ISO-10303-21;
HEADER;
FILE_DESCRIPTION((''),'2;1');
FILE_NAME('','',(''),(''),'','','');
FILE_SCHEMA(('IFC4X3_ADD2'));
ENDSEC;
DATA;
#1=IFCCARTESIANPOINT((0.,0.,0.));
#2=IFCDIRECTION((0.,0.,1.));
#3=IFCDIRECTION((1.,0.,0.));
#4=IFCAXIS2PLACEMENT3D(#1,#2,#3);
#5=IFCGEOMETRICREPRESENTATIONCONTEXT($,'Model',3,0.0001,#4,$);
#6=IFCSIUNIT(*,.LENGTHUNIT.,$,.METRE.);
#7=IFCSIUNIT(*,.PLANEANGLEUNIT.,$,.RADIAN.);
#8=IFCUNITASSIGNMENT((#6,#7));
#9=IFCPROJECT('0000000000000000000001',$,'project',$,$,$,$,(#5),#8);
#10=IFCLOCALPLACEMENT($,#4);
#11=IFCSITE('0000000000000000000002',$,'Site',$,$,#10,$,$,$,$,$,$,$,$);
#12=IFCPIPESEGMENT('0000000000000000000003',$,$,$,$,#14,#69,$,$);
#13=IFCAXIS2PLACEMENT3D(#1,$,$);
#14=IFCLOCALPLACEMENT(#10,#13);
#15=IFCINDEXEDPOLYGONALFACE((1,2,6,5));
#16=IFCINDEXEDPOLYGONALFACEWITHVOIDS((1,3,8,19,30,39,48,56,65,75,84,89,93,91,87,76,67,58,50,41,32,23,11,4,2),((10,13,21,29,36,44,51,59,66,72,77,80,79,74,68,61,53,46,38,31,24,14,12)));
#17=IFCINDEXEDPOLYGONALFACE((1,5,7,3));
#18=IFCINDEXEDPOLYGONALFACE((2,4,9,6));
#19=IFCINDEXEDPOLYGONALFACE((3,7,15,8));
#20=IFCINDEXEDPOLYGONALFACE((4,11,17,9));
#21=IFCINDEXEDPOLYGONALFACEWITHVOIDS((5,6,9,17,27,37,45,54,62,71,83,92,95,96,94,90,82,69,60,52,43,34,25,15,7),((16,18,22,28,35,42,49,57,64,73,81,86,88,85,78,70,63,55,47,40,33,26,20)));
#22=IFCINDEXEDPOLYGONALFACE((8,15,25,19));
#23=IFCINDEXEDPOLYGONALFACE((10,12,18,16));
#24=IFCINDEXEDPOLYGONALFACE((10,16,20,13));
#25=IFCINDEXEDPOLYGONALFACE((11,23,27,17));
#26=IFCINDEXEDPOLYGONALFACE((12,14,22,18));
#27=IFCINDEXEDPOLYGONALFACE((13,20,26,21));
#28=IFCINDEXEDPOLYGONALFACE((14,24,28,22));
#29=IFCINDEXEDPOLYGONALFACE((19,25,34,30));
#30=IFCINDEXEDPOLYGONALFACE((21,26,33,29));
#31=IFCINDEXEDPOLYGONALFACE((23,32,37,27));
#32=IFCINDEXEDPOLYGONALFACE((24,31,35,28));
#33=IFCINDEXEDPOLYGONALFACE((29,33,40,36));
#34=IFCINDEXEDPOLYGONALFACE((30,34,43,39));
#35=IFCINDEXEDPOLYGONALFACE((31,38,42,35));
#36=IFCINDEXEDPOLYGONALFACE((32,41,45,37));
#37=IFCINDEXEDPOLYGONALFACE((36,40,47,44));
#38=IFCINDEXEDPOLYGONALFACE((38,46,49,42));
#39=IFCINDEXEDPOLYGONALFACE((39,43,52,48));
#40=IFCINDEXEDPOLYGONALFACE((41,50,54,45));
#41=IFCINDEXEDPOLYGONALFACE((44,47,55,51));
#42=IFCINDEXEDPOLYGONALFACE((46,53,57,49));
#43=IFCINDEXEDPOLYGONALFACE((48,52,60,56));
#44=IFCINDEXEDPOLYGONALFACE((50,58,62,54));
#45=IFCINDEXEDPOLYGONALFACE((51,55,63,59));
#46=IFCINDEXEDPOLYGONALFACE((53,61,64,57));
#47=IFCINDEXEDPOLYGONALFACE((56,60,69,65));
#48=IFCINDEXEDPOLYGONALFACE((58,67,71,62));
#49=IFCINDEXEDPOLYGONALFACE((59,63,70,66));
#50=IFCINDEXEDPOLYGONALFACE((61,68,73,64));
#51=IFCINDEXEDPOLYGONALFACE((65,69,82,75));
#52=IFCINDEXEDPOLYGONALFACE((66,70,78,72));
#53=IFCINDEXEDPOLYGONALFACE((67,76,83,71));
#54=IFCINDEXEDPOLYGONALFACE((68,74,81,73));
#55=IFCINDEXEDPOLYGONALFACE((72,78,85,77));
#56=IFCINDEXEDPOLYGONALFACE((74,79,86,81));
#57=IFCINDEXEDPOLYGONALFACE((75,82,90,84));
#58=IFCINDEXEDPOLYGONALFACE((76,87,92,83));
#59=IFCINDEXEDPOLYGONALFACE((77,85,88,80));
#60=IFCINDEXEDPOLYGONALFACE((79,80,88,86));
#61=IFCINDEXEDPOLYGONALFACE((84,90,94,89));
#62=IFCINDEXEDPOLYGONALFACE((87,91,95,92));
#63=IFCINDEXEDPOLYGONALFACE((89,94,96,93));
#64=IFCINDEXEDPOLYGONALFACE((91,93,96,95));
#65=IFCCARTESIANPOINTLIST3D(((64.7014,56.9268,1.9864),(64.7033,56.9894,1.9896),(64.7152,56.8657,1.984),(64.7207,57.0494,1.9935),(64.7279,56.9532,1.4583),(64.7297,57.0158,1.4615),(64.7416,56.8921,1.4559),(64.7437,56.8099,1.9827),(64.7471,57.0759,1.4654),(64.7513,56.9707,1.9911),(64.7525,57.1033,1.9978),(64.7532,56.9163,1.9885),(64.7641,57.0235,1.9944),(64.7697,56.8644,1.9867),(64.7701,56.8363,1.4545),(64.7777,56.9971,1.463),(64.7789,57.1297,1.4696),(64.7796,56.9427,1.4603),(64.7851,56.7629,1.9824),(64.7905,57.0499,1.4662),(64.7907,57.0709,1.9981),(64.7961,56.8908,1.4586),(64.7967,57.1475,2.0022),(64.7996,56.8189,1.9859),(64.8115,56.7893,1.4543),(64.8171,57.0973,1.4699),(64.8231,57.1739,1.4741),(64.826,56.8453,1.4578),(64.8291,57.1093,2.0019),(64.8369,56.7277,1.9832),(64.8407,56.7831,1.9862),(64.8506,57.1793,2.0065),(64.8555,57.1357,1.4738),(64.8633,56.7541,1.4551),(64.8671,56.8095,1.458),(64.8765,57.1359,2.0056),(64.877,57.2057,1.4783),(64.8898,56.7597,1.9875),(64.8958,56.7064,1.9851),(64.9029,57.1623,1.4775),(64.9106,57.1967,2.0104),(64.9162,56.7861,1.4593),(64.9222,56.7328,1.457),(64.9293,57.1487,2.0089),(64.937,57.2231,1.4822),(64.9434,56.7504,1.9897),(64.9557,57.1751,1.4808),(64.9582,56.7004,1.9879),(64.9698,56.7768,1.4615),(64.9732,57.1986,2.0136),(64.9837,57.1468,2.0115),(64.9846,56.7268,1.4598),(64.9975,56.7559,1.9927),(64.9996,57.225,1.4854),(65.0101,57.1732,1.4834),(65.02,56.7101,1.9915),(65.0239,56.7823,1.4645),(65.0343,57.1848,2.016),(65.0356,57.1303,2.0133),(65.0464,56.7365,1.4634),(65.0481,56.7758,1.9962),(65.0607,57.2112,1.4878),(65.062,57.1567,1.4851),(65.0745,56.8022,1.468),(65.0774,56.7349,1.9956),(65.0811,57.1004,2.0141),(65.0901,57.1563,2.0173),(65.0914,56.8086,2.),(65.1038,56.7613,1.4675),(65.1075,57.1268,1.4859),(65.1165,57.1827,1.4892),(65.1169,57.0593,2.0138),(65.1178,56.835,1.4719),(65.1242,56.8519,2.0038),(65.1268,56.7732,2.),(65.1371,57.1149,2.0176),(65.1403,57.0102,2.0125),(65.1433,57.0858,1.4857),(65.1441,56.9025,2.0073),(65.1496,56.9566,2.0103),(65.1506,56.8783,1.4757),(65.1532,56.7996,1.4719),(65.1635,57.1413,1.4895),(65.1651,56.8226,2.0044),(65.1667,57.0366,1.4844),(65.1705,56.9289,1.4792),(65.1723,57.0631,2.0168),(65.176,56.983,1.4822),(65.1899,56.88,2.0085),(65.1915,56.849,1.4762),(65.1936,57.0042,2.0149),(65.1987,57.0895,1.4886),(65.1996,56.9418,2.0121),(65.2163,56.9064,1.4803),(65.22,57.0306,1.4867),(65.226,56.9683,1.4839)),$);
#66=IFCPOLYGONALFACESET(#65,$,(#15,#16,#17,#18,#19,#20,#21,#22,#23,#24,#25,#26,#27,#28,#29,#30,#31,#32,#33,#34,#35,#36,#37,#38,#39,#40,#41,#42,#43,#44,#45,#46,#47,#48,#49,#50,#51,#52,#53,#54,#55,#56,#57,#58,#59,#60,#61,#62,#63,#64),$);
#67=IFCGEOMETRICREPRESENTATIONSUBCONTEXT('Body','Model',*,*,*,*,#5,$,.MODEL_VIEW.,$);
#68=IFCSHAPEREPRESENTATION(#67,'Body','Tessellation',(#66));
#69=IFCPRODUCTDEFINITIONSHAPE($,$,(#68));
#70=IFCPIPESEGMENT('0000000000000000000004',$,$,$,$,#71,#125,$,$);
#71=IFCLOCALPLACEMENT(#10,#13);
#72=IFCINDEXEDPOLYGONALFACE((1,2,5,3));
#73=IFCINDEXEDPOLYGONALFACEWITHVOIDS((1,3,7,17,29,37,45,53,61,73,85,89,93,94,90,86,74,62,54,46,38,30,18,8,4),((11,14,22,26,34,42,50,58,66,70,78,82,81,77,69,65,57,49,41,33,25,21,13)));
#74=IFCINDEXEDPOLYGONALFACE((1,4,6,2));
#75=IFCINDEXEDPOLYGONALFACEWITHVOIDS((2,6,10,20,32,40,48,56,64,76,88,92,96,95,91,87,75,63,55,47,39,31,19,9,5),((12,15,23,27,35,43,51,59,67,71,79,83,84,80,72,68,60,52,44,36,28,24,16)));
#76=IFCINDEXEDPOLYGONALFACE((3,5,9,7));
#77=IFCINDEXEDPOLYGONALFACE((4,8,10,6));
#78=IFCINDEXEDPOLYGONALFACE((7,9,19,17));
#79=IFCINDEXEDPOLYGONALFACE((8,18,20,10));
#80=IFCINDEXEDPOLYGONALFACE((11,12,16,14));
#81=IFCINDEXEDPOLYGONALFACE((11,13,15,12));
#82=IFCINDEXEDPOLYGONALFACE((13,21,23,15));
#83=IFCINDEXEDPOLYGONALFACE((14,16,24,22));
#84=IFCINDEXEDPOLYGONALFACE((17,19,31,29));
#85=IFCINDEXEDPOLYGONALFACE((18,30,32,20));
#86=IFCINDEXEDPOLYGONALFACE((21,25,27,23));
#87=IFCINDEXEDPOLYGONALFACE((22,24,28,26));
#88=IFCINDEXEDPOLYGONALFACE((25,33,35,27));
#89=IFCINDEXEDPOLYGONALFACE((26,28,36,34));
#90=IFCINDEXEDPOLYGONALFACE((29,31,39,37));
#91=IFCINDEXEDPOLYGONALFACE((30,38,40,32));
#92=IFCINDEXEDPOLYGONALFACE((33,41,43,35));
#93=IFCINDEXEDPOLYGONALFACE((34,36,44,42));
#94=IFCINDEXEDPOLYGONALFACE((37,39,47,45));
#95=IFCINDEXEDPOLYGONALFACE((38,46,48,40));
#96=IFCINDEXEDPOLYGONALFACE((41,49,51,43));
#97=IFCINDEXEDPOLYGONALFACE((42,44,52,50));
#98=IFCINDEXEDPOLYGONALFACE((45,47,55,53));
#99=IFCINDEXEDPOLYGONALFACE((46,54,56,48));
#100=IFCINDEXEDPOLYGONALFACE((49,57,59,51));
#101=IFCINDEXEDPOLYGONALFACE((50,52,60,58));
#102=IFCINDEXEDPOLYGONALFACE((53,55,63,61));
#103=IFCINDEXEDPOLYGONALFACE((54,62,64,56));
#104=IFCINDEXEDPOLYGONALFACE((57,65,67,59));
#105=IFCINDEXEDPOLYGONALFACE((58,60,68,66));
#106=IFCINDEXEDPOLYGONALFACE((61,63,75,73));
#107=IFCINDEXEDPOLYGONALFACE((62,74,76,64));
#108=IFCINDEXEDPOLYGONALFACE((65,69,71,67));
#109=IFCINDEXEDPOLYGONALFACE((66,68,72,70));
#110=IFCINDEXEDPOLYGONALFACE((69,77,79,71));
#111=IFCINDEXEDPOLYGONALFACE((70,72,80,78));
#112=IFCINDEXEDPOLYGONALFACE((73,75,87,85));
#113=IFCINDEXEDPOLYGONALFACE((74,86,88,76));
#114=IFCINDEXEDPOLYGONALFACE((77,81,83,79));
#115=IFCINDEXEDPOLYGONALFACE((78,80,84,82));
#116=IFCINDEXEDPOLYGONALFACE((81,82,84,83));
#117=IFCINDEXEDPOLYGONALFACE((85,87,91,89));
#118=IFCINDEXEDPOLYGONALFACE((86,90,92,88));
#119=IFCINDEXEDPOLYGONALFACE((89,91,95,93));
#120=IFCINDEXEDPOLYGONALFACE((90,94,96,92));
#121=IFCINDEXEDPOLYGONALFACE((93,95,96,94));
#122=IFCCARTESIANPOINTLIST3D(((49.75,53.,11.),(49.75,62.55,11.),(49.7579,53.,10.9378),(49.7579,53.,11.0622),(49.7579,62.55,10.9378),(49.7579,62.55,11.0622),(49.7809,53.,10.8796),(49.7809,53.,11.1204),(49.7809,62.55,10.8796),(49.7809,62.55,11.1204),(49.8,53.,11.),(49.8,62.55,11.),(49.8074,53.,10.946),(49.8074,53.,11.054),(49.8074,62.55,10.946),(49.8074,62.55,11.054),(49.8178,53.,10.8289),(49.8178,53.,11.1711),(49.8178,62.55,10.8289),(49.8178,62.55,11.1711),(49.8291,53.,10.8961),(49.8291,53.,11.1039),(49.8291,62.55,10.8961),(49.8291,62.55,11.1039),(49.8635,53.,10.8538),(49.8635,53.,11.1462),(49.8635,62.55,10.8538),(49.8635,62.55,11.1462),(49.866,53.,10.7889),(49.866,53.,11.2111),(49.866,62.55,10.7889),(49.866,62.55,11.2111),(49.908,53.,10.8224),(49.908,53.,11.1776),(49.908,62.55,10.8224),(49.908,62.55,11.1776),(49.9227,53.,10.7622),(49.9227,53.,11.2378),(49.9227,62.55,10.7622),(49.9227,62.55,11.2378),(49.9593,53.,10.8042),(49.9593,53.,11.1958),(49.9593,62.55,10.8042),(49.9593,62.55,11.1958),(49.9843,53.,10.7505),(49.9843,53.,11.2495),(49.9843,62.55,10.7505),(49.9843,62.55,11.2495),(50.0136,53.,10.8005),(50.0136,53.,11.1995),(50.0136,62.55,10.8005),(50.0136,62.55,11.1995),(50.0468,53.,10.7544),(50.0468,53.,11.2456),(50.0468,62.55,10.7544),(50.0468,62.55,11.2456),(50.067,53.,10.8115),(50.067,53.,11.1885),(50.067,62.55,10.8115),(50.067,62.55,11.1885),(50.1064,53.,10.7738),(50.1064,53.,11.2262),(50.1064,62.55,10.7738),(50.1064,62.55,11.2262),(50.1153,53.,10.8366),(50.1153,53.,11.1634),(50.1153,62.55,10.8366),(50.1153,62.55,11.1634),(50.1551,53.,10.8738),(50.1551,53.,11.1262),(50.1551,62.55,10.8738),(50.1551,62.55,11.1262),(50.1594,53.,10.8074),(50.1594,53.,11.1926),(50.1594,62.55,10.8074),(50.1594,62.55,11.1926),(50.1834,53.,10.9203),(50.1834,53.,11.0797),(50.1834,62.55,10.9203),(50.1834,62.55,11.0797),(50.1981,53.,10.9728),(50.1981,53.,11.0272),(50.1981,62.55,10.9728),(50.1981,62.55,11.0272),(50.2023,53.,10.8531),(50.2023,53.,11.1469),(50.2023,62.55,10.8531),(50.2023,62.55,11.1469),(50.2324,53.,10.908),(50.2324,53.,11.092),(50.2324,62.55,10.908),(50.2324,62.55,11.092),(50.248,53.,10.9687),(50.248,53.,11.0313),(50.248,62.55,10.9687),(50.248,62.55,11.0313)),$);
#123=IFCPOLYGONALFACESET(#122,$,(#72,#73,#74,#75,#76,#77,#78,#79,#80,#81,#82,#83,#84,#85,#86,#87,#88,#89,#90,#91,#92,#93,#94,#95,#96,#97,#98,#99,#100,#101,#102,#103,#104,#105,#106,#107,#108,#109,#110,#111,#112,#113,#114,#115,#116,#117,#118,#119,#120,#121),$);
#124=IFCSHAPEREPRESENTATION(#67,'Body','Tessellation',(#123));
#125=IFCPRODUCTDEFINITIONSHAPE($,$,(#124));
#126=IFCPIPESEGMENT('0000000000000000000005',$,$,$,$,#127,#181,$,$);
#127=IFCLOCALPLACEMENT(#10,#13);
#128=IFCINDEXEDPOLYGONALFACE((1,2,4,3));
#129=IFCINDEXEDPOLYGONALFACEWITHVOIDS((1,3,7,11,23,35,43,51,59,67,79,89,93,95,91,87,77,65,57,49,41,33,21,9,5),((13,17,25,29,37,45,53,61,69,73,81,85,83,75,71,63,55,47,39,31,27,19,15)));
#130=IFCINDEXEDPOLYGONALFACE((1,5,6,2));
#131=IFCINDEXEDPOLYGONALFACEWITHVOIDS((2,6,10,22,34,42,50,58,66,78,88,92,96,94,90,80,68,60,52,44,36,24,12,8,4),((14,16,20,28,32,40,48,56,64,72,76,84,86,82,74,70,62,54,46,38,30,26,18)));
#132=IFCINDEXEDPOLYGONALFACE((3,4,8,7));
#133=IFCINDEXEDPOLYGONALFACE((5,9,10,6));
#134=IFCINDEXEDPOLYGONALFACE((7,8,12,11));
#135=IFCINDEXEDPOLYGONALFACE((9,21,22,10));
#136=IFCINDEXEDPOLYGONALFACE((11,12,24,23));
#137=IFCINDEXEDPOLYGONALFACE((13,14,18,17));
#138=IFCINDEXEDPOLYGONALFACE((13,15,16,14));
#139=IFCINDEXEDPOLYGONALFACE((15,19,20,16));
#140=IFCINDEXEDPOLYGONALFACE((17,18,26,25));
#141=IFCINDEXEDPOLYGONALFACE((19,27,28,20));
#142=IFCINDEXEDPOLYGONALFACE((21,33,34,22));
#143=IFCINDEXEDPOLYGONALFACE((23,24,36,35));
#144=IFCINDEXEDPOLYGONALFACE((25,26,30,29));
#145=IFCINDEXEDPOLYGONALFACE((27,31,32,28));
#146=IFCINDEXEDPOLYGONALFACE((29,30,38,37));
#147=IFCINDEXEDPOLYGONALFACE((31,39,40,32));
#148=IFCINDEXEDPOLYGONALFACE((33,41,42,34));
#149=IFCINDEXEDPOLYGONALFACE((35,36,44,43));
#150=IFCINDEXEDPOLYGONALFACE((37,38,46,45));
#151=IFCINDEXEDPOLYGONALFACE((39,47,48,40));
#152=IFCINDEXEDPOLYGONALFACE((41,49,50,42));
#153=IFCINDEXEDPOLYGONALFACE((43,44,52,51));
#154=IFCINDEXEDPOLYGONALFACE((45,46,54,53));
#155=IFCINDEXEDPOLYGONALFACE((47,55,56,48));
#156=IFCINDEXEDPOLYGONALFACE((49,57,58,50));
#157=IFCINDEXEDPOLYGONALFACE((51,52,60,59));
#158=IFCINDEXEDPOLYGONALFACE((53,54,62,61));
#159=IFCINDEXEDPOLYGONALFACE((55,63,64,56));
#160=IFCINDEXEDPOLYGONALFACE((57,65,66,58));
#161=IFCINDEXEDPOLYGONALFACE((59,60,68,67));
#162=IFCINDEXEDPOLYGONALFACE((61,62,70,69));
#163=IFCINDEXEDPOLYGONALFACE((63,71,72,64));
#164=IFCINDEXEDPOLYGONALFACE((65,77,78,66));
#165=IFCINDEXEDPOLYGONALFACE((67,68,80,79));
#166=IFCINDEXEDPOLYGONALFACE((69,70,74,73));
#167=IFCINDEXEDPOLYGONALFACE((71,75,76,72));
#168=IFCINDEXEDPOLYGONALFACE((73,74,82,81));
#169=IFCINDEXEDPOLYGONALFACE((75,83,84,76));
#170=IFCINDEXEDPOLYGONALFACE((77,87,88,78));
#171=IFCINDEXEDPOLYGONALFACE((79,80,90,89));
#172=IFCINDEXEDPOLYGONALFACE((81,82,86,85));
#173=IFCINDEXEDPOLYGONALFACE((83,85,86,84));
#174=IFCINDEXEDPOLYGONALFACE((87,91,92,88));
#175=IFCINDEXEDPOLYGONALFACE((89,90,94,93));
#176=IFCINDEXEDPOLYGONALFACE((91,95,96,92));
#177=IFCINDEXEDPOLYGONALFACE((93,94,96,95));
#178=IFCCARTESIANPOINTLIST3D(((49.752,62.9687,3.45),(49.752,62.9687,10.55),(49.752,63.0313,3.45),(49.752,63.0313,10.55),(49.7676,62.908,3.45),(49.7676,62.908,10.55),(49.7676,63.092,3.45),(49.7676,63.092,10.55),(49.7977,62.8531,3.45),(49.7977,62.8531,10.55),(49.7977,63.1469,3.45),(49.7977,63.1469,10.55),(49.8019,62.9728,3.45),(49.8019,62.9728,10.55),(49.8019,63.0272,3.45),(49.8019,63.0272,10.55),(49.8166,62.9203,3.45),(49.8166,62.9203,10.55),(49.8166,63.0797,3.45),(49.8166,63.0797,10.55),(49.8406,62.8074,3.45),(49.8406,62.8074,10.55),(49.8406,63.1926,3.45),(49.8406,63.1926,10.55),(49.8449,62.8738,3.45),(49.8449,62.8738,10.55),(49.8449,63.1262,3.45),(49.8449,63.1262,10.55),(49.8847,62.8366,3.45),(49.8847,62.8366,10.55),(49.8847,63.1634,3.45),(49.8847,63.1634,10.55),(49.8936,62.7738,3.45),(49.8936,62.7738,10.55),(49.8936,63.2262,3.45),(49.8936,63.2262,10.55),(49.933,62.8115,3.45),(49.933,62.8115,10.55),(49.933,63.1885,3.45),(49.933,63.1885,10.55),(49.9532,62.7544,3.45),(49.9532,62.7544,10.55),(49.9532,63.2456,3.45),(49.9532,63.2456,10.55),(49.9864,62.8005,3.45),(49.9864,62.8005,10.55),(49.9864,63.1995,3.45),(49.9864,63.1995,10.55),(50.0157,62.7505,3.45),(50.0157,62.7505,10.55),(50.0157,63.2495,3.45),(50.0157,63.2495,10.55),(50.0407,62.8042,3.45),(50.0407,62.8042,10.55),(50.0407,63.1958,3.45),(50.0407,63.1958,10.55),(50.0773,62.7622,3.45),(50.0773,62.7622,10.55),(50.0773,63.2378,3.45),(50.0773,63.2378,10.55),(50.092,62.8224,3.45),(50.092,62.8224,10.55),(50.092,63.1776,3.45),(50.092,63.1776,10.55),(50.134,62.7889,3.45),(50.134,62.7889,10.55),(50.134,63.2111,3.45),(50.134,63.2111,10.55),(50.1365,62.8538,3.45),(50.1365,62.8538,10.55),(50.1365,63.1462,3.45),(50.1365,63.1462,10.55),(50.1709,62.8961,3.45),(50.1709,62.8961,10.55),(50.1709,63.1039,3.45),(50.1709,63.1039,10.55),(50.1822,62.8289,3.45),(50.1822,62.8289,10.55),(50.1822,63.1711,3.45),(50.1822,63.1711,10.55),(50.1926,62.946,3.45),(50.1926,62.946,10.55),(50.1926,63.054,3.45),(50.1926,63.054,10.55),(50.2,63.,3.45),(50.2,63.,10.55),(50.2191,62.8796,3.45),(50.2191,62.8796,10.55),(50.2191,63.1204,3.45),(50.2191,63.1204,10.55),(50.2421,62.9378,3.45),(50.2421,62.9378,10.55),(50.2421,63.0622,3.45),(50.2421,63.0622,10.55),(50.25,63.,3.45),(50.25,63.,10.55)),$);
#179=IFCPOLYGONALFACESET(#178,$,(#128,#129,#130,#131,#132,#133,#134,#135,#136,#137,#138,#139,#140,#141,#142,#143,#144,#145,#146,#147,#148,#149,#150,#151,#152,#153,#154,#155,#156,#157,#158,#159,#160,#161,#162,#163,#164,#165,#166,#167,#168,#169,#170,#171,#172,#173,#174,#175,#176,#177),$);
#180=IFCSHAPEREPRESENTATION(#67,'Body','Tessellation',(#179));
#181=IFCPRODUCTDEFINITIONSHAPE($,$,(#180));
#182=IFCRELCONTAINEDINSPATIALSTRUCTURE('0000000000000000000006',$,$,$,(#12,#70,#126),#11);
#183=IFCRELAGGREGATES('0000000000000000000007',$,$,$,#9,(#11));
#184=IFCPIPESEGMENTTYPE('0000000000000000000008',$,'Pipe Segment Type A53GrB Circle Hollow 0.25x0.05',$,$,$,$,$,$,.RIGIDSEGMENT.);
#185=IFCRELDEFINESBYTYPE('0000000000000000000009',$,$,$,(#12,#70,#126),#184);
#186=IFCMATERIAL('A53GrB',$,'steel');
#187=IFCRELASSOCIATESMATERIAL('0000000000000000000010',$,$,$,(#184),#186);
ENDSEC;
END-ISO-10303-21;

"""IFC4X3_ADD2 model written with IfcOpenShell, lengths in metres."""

from ifc_helpers import new_model, si_unit, frame, origin_with_axes, place, context, subcontext, project, spatial, hollow_circle, extrude, material, material_profile, profile_set, type_object, element, save


model = new_model("IFC4X3_ADD2")

# Units and contexts
model_context = context("Model", 3, precision=0.0001, world=origin_with_axes())
body_context = subcontext(model_context, "Body", "Model", "MODEL_VIEW")
ifc_project = project(units=[si_unit("LENGTHUNIT", "METRE"), si_unit("PLANEANGLEUNIT", "RADIAN")], contexts=[model_context])

# Site
site_placement = place(None, origin_with_axes())
site = spatial("IfcSite", under=ifc_project, at=site_placement, Name="Site")

# Pipe segments
ifc_material = material(Name="A53GrB", Category="steel")
ifc_material_profile = material_profile(ifc_material, hollow_circle(Radius=0.25, WallThickness=0.05))
ifc_profile_set = profile_set([ifc_material_profile], Name="A53GrB steel Circle Hollow 0.25x0.05")
pipe_segment_type = type_object("IfcPipeSegmentType", Name="Pipe Segment Type A53GrB Circle Hollow 0.25x0.05", PredefinedType="RIGIDSEGMENT", material=ifc_profile_set)
pipe_segment_1_placement = place(None, frame((64.9764, 56.9764, 1.4719), z_axis=(-0.049875, -0.049875, 0.997509), x_axis=(0.707107, -0.707107, 0.0)))
element("IfcPipeSegment", 1, at=pipe_segment_1_placement, inside=site, type_object=pipe_segment_type, context=body_context, shape_type="SweptSolid", body=[
    extrude(hollow_circle(Radius=0.25, WallThickness=0.05), origin_with_axes(), (0.0, 0.0, 1.0), 0.5295),
])
pipe_segment_2_placement = place(None, frame((50.0, 53.0, 11.0), z_axis=(0.0, 1.0, 0.0), x_axis=(-1.0, 0.0, 0.0)))
element("IfcPipeSegment", 2, at=pipe_segment_2_placement, inside=site, type_object=pipe_segment_type, context=body_context, shape_type="SweptSolid", body=[
    extrude(hollow_circle(Radius=0.25, WallThickness=0.05), origin_with_axes(), (0.0, 0.0, 1.0), 9.55),
])
pipe_segment_3_placement = place(None, frame((50.0, 63.0, 10.55), z_axis=(0.0, 0.0, -1.0), x_axis=(1.0, 0.0, 0.0)))
element("IfcPipeSegment", 3, at=pipe_segment_3_placement, inside=site, type_object=pipe_segment_type, context=body_context, shape_type="SweptSolid", body=[
    extrude(hollow_circle(Radius=0.25, WallThickness=0.05), origin_with_axes(), (0.0, 0.0, 1.0), 7.1),
])

save(model, "model.ifc")
